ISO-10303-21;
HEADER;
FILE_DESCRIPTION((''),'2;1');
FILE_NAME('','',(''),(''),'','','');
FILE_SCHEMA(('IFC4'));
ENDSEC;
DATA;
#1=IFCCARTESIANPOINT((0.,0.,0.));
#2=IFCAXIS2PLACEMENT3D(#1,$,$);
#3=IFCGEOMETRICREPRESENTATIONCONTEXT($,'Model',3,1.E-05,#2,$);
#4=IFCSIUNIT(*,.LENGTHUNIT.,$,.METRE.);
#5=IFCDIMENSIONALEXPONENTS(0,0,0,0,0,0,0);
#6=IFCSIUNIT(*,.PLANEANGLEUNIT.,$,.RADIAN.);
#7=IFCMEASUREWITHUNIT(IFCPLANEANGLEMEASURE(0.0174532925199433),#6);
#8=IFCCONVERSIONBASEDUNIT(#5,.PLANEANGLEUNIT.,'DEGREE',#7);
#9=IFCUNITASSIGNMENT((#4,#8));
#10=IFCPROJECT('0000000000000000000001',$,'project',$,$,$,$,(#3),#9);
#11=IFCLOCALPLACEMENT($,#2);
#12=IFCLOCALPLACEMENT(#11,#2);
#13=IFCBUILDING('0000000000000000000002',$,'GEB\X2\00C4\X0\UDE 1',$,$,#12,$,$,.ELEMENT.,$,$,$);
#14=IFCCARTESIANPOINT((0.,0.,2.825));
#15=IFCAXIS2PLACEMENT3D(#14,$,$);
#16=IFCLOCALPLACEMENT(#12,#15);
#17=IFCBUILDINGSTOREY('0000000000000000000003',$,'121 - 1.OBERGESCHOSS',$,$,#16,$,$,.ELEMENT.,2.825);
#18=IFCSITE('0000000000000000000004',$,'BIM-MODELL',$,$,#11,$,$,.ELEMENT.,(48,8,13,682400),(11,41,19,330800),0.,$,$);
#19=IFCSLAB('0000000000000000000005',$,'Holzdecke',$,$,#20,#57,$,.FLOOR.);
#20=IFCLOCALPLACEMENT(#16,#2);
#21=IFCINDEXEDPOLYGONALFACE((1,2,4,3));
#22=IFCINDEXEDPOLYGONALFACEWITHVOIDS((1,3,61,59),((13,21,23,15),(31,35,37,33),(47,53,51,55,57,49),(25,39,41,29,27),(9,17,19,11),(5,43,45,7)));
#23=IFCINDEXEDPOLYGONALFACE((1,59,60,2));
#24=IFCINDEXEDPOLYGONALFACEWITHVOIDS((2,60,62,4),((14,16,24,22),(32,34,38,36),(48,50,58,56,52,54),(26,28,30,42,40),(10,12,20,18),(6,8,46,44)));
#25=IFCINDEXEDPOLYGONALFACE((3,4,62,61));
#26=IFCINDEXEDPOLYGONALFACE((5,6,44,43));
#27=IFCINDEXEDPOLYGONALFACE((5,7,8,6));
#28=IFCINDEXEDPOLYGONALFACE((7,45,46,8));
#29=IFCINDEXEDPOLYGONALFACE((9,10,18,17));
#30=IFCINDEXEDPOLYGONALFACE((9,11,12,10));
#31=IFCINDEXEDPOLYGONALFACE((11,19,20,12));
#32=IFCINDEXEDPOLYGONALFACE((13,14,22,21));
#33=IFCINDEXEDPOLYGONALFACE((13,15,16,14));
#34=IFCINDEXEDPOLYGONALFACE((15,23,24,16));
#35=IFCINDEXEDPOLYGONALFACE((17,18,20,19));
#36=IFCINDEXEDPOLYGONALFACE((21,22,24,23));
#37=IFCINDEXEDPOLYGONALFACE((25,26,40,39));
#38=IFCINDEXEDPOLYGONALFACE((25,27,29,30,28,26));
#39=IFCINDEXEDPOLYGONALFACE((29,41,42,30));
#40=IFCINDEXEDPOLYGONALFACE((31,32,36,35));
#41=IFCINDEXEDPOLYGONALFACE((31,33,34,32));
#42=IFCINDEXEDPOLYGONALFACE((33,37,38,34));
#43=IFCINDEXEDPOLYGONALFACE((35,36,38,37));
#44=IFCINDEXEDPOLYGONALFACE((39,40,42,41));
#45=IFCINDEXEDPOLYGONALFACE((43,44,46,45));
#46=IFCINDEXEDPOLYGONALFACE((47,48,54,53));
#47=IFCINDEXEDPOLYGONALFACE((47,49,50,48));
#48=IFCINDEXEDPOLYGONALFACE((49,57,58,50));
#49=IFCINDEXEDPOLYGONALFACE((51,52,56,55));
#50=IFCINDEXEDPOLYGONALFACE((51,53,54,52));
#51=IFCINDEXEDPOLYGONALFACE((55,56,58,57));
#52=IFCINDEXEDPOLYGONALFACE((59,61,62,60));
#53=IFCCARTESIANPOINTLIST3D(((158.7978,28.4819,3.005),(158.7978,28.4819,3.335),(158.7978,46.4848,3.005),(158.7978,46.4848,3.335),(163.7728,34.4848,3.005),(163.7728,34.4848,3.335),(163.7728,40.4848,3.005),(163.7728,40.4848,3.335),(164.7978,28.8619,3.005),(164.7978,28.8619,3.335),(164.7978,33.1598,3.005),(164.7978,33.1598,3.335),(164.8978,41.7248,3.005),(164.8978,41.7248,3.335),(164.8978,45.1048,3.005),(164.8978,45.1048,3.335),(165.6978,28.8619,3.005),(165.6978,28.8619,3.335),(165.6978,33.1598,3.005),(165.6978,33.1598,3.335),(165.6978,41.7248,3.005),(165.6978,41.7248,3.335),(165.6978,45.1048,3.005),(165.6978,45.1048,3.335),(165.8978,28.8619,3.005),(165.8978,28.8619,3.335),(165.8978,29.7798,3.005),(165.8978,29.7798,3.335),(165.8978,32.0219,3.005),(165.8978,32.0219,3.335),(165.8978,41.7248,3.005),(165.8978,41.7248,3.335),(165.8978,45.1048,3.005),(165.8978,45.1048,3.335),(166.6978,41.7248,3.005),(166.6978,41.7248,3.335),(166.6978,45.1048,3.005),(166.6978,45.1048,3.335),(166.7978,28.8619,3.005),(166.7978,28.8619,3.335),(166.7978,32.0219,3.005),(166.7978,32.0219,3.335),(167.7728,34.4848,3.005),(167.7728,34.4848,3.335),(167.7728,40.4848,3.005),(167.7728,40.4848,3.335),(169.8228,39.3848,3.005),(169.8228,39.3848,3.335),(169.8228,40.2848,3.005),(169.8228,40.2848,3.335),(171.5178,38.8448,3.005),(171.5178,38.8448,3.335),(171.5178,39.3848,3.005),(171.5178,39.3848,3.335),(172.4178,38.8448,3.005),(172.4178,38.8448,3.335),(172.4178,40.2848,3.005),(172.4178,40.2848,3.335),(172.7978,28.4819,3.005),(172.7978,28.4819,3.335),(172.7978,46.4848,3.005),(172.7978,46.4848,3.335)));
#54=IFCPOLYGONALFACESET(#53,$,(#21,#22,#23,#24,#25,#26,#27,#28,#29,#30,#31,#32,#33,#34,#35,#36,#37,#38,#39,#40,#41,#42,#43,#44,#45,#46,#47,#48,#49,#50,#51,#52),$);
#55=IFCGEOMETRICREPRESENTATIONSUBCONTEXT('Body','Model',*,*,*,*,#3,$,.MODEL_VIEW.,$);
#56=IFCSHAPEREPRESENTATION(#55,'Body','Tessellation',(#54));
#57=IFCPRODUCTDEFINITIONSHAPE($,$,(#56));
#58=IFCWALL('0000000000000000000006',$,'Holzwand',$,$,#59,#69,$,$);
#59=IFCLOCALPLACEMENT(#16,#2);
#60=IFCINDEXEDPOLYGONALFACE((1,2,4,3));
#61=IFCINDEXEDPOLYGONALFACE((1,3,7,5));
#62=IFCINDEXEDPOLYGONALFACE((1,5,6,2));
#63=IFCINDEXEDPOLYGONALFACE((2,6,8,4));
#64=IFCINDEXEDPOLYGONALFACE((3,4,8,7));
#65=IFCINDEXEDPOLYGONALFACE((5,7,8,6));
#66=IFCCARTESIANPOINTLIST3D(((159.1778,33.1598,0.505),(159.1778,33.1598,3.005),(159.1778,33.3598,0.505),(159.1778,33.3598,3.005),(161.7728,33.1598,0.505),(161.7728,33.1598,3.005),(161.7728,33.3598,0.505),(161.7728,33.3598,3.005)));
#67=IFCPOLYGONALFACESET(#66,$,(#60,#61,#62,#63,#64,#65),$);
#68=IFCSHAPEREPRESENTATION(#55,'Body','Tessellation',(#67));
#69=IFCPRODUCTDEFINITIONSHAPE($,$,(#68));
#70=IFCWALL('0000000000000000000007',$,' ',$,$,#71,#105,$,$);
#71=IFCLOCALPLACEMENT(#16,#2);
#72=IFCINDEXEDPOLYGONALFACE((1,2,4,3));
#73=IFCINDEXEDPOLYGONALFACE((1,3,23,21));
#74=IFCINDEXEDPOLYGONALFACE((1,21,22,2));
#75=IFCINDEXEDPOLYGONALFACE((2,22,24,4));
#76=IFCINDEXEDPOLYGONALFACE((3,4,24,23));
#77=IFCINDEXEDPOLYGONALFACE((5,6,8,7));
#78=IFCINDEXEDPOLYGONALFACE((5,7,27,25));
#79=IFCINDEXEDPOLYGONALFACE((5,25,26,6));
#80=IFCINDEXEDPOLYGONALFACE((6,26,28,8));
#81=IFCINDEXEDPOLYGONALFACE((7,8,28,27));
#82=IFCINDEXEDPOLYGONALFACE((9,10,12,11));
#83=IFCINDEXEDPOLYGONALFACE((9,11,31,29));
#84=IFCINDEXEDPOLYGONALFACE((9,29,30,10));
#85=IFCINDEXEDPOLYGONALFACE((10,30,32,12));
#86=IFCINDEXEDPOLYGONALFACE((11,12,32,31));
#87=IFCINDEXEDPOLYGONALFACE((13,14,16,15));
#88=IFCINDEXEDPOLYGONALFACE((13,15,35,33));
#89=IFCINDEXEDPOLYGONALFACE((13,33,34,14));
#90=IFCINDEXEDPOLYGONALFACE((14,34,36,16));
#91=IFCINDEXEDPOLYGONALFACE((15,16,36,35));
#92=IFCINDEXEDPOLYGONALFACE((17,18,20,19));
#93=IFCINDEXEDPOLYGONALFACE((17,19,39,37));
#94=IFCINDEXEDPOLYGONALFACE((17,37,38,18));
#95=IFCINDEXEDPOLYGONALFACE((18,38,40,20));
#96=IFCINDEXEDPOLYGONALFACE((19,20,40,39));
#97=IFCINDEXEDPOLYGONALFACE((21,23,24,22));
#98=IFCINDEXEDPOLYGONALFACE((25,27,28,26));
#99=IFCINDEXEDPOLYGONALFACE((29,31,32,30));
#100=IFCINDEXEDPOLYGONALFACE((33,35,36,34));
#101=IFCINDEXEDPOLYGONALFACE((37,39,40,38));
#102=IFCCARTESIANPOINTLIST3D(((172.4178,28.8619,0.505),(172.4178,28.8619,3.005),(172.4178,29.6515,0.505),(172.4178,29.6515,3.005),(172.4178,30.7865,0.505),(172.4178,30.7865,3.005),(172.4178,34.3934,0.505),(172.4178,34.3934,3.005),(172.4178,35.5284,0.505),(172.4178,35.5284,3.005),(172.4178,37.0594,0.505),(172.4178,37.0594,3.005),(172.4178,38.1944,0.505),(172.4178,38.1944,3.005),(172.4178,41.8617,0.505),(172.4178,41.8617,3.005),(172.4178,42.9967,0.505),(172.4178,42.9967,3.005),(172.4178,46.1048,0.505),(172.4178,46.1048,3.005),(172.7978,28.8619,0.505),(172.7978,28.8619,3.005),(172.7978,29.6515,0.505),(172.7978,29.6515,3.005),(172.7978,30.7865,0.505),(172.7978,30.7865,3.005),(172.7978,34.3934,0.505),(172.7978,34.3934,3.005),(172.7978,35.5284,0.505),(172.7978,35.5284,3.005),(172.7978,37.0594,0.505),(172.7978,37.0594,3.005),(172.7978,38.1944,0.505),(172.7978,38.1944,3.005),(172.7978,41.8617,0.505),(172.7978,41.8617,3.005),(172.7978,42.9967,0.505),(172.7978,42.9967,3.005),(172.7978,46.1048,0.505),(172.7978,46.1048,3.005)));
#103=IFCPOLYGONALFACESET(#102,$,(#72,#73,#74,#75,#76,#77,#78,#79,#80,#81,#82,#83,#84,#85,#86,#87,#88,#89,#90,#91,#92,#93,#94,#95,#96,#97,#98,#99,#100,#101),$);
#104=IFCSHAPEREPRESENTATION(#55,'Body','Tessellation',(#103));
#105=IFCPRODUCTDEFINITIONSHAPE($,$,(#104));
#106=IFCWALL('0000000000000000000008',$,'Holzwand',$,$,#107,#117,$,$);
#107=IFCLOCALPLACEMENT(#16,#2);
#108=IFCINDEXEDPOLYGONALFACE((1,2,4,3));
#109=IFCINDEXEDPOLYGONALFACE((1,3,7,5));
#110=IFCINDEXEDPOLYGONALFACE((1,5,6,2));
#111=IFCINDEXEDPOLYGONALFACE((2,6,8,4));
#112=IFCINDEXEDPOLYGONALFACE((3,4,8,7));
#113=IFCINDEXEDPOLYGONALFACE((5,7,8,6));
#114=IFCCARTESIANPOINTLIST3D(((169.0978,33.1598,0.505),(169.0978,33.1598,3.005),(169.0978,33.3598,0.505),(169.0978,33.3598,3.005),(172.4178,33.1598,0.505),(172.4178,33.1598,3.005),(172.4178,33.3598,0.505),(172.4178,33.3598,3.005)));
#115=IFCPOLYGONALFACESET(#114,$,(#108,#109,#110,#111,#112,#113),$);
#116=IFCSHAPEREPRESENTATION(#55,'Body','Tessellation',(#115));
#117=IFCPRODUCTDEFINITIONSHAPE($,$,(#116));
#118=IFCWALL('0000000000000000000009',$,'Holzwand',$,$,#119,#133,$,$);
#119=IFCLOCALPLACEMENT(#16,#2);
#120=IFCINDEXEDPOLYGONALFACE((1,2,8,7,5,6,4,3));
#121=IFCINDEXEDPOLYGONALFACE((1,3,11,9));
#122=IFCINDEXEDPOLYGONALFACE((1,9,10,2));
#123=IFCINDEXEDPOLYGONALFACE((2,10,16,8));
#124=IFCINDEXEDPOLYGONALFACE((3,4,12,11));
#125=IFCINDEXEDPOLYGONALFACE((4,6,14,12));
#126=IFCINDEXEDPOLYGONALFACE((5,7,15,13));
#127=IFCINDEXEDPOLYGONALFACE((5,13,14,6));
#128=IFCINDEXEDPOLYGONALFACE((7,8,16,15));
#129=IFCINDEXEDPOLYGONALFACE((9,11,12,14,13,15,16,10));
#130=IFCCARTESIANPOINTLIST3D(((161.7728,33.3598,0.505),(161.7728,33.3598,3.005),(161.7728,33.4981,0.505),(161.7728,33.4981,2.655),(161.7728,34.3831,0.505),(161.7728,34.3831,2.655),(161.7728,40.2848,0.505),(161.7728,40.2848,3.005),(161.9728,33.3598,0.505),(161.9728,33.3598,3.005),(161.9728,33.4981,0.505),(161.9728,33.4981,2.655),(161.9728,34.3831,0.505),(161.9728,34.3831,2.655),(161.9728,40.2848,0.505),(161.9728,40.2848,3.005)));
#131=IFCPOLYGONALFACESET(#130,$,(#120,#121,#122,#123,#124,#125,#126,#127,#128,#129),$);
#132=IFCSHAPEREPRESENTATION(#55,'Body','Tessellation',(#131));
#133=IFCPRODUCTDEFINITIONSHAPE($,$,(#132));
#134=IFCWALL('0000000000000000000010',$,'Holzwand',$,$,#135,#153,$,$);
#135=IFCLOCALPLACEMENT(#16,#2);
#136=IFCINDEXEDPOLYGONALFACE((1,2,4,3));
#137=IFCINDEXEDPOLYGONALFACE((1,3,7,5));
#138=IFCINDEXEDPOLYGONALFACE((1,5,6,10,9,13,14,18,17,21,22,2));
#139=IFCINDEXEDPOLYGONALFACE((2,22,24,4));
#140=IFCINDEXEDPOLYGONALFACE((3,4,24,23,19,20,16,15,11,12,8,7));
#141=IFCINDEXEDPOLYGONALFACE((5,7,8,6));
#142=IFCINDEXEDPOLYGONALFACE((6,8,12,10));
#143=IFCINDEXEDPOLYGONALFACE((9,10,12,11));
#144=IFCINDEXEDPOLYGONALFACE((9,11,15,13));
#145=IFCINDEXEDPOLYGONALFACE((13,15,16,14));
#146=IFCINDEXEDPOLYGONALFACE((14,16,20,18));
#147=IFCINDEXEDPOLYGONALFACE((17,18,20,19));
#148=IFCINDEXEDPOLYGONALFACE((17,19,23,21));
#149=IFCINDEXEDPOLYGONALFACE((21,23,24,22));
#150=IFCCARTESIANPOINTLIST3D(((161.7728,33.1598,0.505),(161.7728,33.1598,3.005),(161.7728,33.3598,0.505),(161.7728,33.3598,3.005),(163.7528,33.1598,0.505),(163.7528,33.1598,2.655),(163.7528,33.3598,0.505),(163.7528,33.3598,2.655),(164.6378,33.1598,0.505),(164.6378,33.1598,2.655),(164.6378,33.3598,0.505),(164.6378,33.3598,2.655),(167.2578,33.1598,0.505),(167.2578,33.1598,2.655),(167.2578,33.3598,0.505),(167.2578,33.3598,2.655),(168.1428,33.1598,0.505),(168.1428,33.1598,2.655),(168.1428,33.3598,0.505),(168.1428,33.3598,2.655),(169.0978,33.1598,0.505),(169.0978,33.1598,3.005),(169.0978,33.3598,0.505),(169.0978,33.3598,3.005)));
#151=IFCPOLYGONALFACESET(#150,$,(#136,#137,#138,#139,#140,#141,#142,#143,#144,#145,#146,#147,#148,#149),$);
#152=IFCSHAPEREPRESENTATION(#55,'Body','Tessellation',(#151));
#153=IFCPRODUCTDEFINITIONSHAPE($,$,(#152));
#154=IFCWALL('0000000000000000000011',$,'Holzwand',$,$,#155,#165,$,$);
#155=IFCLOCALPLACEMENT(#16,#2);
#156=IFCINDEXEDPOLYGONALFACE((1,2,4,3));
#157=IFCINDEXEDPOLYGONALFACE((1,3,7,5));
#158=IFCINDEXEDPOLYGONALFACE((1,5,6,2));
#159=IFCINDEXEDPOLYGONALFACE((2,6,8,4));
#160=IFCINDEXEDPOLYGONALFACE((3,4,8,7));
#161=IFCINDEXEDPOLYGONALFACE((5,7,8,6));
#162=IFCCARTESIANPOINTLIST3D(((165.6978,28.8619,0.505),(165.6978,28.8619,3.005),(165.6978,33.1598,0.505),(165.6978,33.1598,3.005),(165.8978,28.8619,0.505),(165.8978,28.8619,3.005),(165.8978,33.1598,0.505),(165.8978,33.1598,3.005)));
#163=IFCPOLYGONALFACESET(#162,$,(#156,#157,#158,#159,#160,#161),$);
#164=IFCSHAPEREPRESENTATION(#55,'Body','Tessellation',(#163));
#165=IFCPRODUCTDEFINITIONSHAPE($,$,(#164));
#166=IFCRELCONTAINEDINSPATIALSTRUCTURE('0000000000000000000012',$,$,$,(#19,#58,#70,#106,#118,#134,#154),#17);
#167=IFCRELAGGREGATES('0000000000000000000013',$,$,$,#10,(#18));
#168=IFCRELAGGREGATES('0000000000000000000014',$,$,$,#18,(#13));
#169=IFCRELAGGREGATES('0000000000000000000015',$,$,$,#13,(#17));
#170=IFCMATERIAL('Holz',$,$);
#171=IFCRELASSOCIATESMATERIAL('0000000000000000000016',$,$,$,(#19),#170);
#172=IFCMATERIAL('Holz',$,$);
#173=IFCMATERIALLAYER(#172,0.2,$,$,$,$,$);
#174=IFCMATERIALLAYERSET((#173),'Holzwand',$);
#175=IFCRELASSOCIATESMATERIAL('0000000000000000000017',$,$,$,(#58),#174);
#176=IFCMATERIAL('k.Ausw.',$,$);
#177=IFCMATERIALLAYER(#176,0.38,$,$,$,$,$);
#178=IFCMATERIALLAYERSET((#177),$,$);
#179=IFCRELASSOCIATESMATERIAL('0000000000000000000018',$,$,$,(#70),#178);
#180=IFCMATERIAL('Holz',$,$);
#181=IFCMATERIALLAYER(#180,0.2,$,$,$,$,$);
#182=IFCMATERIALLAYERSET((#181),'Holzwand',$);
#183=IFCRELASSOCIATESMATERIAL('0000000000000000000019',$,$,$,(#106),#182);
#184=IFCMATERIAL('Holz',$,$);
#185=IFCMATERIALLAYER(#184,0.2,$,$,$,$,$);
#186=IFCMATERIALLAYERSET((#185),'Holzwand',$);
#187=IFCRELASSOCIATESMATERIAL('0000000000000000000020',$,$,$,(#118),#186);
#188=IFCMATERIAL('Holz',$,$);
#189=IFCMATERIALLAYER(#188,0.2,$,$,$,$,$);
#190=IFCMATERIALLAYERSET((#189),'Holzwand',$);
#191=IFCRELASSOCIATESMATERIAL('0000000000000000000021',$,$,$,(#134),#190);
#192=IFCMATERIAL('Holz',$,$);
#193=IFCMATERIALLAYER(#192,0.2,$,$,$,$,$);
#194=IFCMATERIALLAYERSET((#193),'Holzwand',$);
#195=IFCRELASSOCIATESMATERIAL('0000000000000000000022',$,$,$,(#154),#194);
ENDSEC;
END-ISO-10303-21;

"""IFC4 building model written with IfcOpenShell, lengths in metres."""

from ifc_helpers import new_model, entity, si_unit, converted_unit, frame, frame_2d, origin, origin_with_axes, place, context, subcontext, project, spatial, polyline, rectangle, outline, extrude, material, layer, layer_set, layer_usage, element, save


model = new_model("IFC4")

# Units and contexts
model_context = context("Model", 3, precision=1e-05, world=origin())
body_context = subcontext(model_context, "Body", "Model", "MODEL_VIEW")
ifc_project = project(units=[si_unit("LENGTHUNIT", "METRE"), converted_unit("PLANEANGLEUNIT", "DEGREE", entity("IfcPlaneAngleMeasure", 0.0174532925199433), si_unit("PLANEANGLEUNIT", "RADIAN"), dimensions=[0, 0, 0, 0, 0, 0, 0])], contexts=[model_context])

# Site, building, storey
site_placement = place(None, origin())
site = spatial("IfcSite", under=ifc_project, at=site_placement, Name="BIM-MODELL", CompositionType="ELEMENT", RefLatitude=(48, 8, 13, 682400), RefLongitude=(11, 41, 19, 330800), RefElevation=0.0)
building_placement = place(site_placement, origin())
building = spatial("IfcBuilding", under=site, at=building_placement, Name="GEBÄUDE 1", CompositionType="ELEMENT")
storey_placement = place(building_placement, frame((0.0, 0.0, 2.825)))
storey = spatial("IfcBuildingStorey", under=building, at=storey_placement, Name="121 - 1.OBERGESCHOSS", CompositionType="ELEMENT", Elevation=2.825)

# Slab
ifc_material_1 = material(Name="Holz")
slab_placement = place(storey_placement, frame((158.7978, 28.4819, 3.005)))
element("IfcSlab", 1, at=slab_placement, inside=storey, material=ifc_material_1, Name="Holzdecke", PredefinedType="FLOOR", context=body_context, shape_type="SweptSolid", body=[
    extrude(outline(polyline([(0.0, 0.0), (14.0, 0.0), (14.0, 18.0029), (0.0, 18.0029), (0.0, 0.0)]), holes=[polyline([(4.975, 12.0029), (8.975, 12.0029), (8.975, 6.0029), (4.975, 6.0029), (4.975, 12.0029)]), polyline([(6.0, 4.6779), (6.9, 4.6779), (6.9, 0.38), (6.0, 0.38), (6.0, 4.6779)]), polyline([(7.1, 1.2979), (7.1, 3.54), (8.0, 3.54), (8.0, 0.38), (7.1, 0.38), (7.1, 1.2979)]), polyline([(13.62, 10.3629), (12.72, 10.3629), (12.72, 10.9029), (11.025, 10.9029), (11.025, 11.8029), (13.62, 11.8029), (13.62, 10.3629)]), polyline([(7.1, 13.2429), (7.1, 16.6229), (7.9, 16.6229), (7.9, 13.2429), (7.1, 13.2429)]), polyline([(6.9, 13.2429), (6.1, 13.2429), (6.1, 16.6229), (6.9, 16.6229), (6.9, 13.2429)])]), origin_with_axes(), (0.0, 0.0, 1.0), 0.33),
])

# Wall
ifc_material_2 = material(Name="Holz")
ifc_layer_1 = layer(ifc_material_2, 0.2)
ifc_layer_set_1 = layer_set([ifc_layer_1], Name="Holzwand")
ifc_layer_usage_1 = layer_usage(ifc_layer_set_1, "AXIS2", "POSITIVE", 0.0)
wall_1_placement = place(storey_placement, frame((159.1778, 33.1598, 0.505)))
element("IfcWall", 2, at=wall_1_placement, inside=storey, material=ifc_layer_usage_1, Name="Holzwand", context=body_context, shape_type="SweptSolid", body=[
    extrude(rectangle(XDim=2.595, YDim=0.2, at=frame_2d((1.2975, 0.1), x_axis=(1.0, 0.0))), origin_with_axes(), (0.0, 0.0, 1.0), 2.5),
])

# Wall, openings
ifc_material_3 = material(Name="k.Ausw.")
ifc_layer_2 = layer(ifc_material_3, 0.38)
ifc_layer_set_2 = layer_set([ifc_layer_2])
ifc_layer_usage_2 = layer_usage(ifc_layer_set_2, "AXIS2", "POSITIVE", 0.0)
wall_2_placement = place(storey_placement, frame((172.7978, 28.8619, 0.505), z_axis=(0.0, 0.0, 1.0), x_axis=(0.0, 1.0, 0.0)))
wall_2 = element("IfcWall", 3, at=wall_2_placement, inside=storey, material=ifc_layer_usage_2, Name=" ", context=body_context, shape_type="SweptSolid", body=[
    extrude(rectangle(XDim=17.2429, YDim=0.38, at=frame_2d((8.6214, 0.19), x_axis=(1.0, 0.0))), origin_with_axes(), (0.0, 0.0, 1.0), 2.5),
])
opening_1_placement = place(wall_2_placement, frame((14.1348, 0.38, 0.0), z_axis=(0.0, -1.0, 0.0), x_axis=(0.0, 0.0, 1.0)))
element("IfcOpeningElement", 4, at=opening_1_placement, cuts=wall_2, ObjectType="Opening", context=body_context, shape_type="SweptSolid", body=[
    extrude(outline(polyline([(0.0, 1.135), (2.5, 1.135), (2.5, 0.0), (0.0, 0.0), (0.0, 1.135)])), origin_with_axes(), (0.0, 0.0, 1.0), 0.38),
])
opening_2_placement = place(wall_2_placement, frame((9.3325, 0.38, 0.0), z_axis=(0.0, -1.0, 0.0), x_axis=(0.0, 0.0, 1.0)))
element("IfcOpeningElement", 5, at=opening_2_placement, cuts=wall_2, ObjectType="Opening", context=body_context, shape_type="SweptSolid", body=[
    extrude(outline(polyline([(0.0, 1.135), (2.5, 1.135), (2.5, 0.0), (0.0, 0.0), (0.0, 1.135)])), origin_with_axes(), (0.0, 0.0, 1.0), 0.38),
])
opening_3_placement = place(wall_2_placement, frame((6.6664, 0.38, 0.0), z_axis=(0.0, -1.0, 0.0), x_axis=(0.0, 0.0, 1.0)))
element("IfcOpeningElement", 6, at=opening_3_placement, cuts=wall_2, ObjectType="Opening", context=body_context, shape_type="SweptSolid", body=[
    extrude(outline(polyline([(0.0, 1.135), (2.5, 1.135), (2.5, 0.0), (0.0, 0.0), (0.0, 1.135)])), origin_with_axes(), (0.0, 0.0, 1.0), 0.38),
])
opening_4_placement = place(wall_2_placement, frame((1.9246, 0.38, 0.0), z_axis=(0.0, -1.0, 0.0), x_axis=(0.0, 0.0, 1.0)))
element("IfcOpeningElement", 7, at=opening_4_placement, cuts=wall_2, ObjectType="Opening", context=body_context, shape_type="SweptSolid", body=[
    extrude(outline(polyline([(0.0, 1.135), (2.5, 1.135), (2.5, 0.0), (0.0, 0.0), (0.0, 1.135)])), origin_with_axes(), (0.0, 0.0, 1.0), 0.38),
])

# Wall
ifc_material_4 = material(Name="Holz")
ifc_layer_3 = layer(ifc_material_4, 0.2)
ifc_layer_set_3 = layer_set([ifc_layer_3], Name="Holzwand")
ifc_layer_usage_3 = layer_usage(ifc_layer_set_3, "AXIS2", "POSITIVE", 0.0)
wall_3_placement = place(storey_placement, frame((169.0978, 33.1598, 0.505)))
element("IfcWall", 8, at=wall_3_placement, inside=storey, material=ifc_layer_usage_3, Name="Holzwand", context=body_context, shape_type="SweptSolid", body=[
    extrude(rectangle(XDim=3.32, YDim=0.2, at=frame_2d((1.66, 0.1), x_axis=(1.0, 0.0))), origin_with_axes(), (0.0, 0.0, 1.0), 2.5),
])

# Wall, opening
ifc_material_5 = material(Name="Holz")
ifc_layer_4 = layer(ifc_material_5, 0.2)
ifc_layer_set_4 = layer_set([ifc_layer_4], Name="Holzwand")
ifc_layer_usage_4 = layer_usage(ifc_layer_set_4, "AXIS2", "POSITIVE", 0.0)
wall_4_placement = place(storey_placement, frame((161.9728, 33.3598, 0.505), z_axis=(0.0, 0.0, 1.0), x_axis=(0.0, 1.0, 0.0)))
wall_4 = element("IfcWall", 9, at=wall_4_placement, inside=storey, material=ifc_layer_usage_4, Name="Holzwand", context=body_context, shape_type="SweptSolid", body=[
    extrude(rectangle(XDim=6.925, YDim=0.2, at=frame_2d((3.4625, 0.1), x_axis=(1.0, 0.0))), origin_with_axes(), (0.0, 0.0, 1.0), 2.5),
])
opening_5_placement = place(wall_4_placement, frame((0.1383, 0.0, -0.15), z_axis=(0.0, 1.0, 0.0), x_axis=(0.0, 0.0, 1.0)))
element("IfcOpeningElement", 10, at=opening_5_placement, cuts=wall_4, ObjectType="Opening", context=body_context, shape_type="SweptSolid", body=[
    extrude(outline(polyline([(0.0, 0.885), (2.3, 0.885), (2.3, 0.0), (0.0, 0.0), (0.0, 0.885)])), origin_with_axes(), (0.0, 0.0, 1.0), 0.2),
])

# Wall, openings
ifc_material_6 = material(Name="Holz")
ifc_layer_5 = layer(ifc_material_6, 0.2)
ifc_layer_set_5 = layer_set([ifc_layer_5], Name="Holzwand")
ifc_layer_usage_5 = layer_usage(ifc_layer_set_5, "AXIS2", "POSITIVE", 0.0)
wall_5_placement = place(storey_placement, frame((169.0978, 33.3598, 0.505), z_axis=(0.0, 0.0, 1.0), x_axis=(-1.0, 0.0, 0.0)))
wall_5 = element("IfcWall", 11, at=wall_5_placement, inside=storey, material=ifc_layer_usage_5, Name="Holzwand", context=body_context, shape_type="SweptSolid", body=[
    extrude(rectangle(XDim=7.325, YDim=0.2, at=frame_2d((3.6625, 0.1), x_axis=(1.0, 0.0))), origin_with_axes(), (0.0, 0.0, 1.0), 2.5),
])
opening_6_placement = place(wall_5_placement, frame((0.955, 0.0, -0.15), z_axis=(0.0, 1.0, 0.0), x_axis=(0.0, 0.0, 1.0)))
element("IfcOpeningElement", 12, at=opening_6_placement, cuts=wall_5, ObjectType="Opening", context=body_context, shape_type="SweptSolid", body=[
    extrude(outline(polyline([(0.0, 0.885), (2.3, 0.885), (2.3, 0.0), (0.0, 0.0), (0.0, 0.885)])), origin_with_axes(), (0.0, 0.0, 1.0), 0.2),
])
opening_7_placement = place(wall_5_placement, frame((4.46, 0.0, -0.15), z_axis=(0.0, 1.0, 0.0), x_axis=(0.0, 0.0, 1.0)))
element("IfcOpeningElement", 13, at=opening_7_placement, cuts=wall_5, ObjectType="Opening", context=body_context, shape_type="SweptSolid", body=[
    extrude(outline(polyline([(0.0, 0.885), (2.3, 0.885), (2.3, 0.0), (0.0, 0.0), (0.0, 0.885)])), origin_with_axes(), (0.0, 0.0, 1.0), 0.2),
])

# Wall
ifc_material_7 = material(Name="Holz")
ifc_layer_6 = layer(ifc_material_7, 0.2)
ifc_layer_set_6 = layer_set([ifc_layer_6], Name="Holzwand")
ifc_layer_usage_6 = layer_usage(ifc_layer_set_6, "AXIS2", "POSITIVE", 0.0)
wall_6_placement = place(storey_placement, frame((165.6978, 33.1598, 0.505), z_axis=(0.0, 0.0, 1.0), x_axis=(0.0, -1.0, 0.0)))
element("IfcWall", 14, at=wall_6_placement, inside=storey, material=ifc_layer_usage_6, Name="Holzwand", context=body_context, shape_type="SweptSolid", body=[
    extrude(rectangle(XDim=4.2979, YDim=0.2, at=frame_2d((2.1489, 0.1), x_axis=(1.0, 0.0))), origin_with_axes(), (0.0, 0.0, 1.0), 2.5),
])

save(model, "model.ifc")
